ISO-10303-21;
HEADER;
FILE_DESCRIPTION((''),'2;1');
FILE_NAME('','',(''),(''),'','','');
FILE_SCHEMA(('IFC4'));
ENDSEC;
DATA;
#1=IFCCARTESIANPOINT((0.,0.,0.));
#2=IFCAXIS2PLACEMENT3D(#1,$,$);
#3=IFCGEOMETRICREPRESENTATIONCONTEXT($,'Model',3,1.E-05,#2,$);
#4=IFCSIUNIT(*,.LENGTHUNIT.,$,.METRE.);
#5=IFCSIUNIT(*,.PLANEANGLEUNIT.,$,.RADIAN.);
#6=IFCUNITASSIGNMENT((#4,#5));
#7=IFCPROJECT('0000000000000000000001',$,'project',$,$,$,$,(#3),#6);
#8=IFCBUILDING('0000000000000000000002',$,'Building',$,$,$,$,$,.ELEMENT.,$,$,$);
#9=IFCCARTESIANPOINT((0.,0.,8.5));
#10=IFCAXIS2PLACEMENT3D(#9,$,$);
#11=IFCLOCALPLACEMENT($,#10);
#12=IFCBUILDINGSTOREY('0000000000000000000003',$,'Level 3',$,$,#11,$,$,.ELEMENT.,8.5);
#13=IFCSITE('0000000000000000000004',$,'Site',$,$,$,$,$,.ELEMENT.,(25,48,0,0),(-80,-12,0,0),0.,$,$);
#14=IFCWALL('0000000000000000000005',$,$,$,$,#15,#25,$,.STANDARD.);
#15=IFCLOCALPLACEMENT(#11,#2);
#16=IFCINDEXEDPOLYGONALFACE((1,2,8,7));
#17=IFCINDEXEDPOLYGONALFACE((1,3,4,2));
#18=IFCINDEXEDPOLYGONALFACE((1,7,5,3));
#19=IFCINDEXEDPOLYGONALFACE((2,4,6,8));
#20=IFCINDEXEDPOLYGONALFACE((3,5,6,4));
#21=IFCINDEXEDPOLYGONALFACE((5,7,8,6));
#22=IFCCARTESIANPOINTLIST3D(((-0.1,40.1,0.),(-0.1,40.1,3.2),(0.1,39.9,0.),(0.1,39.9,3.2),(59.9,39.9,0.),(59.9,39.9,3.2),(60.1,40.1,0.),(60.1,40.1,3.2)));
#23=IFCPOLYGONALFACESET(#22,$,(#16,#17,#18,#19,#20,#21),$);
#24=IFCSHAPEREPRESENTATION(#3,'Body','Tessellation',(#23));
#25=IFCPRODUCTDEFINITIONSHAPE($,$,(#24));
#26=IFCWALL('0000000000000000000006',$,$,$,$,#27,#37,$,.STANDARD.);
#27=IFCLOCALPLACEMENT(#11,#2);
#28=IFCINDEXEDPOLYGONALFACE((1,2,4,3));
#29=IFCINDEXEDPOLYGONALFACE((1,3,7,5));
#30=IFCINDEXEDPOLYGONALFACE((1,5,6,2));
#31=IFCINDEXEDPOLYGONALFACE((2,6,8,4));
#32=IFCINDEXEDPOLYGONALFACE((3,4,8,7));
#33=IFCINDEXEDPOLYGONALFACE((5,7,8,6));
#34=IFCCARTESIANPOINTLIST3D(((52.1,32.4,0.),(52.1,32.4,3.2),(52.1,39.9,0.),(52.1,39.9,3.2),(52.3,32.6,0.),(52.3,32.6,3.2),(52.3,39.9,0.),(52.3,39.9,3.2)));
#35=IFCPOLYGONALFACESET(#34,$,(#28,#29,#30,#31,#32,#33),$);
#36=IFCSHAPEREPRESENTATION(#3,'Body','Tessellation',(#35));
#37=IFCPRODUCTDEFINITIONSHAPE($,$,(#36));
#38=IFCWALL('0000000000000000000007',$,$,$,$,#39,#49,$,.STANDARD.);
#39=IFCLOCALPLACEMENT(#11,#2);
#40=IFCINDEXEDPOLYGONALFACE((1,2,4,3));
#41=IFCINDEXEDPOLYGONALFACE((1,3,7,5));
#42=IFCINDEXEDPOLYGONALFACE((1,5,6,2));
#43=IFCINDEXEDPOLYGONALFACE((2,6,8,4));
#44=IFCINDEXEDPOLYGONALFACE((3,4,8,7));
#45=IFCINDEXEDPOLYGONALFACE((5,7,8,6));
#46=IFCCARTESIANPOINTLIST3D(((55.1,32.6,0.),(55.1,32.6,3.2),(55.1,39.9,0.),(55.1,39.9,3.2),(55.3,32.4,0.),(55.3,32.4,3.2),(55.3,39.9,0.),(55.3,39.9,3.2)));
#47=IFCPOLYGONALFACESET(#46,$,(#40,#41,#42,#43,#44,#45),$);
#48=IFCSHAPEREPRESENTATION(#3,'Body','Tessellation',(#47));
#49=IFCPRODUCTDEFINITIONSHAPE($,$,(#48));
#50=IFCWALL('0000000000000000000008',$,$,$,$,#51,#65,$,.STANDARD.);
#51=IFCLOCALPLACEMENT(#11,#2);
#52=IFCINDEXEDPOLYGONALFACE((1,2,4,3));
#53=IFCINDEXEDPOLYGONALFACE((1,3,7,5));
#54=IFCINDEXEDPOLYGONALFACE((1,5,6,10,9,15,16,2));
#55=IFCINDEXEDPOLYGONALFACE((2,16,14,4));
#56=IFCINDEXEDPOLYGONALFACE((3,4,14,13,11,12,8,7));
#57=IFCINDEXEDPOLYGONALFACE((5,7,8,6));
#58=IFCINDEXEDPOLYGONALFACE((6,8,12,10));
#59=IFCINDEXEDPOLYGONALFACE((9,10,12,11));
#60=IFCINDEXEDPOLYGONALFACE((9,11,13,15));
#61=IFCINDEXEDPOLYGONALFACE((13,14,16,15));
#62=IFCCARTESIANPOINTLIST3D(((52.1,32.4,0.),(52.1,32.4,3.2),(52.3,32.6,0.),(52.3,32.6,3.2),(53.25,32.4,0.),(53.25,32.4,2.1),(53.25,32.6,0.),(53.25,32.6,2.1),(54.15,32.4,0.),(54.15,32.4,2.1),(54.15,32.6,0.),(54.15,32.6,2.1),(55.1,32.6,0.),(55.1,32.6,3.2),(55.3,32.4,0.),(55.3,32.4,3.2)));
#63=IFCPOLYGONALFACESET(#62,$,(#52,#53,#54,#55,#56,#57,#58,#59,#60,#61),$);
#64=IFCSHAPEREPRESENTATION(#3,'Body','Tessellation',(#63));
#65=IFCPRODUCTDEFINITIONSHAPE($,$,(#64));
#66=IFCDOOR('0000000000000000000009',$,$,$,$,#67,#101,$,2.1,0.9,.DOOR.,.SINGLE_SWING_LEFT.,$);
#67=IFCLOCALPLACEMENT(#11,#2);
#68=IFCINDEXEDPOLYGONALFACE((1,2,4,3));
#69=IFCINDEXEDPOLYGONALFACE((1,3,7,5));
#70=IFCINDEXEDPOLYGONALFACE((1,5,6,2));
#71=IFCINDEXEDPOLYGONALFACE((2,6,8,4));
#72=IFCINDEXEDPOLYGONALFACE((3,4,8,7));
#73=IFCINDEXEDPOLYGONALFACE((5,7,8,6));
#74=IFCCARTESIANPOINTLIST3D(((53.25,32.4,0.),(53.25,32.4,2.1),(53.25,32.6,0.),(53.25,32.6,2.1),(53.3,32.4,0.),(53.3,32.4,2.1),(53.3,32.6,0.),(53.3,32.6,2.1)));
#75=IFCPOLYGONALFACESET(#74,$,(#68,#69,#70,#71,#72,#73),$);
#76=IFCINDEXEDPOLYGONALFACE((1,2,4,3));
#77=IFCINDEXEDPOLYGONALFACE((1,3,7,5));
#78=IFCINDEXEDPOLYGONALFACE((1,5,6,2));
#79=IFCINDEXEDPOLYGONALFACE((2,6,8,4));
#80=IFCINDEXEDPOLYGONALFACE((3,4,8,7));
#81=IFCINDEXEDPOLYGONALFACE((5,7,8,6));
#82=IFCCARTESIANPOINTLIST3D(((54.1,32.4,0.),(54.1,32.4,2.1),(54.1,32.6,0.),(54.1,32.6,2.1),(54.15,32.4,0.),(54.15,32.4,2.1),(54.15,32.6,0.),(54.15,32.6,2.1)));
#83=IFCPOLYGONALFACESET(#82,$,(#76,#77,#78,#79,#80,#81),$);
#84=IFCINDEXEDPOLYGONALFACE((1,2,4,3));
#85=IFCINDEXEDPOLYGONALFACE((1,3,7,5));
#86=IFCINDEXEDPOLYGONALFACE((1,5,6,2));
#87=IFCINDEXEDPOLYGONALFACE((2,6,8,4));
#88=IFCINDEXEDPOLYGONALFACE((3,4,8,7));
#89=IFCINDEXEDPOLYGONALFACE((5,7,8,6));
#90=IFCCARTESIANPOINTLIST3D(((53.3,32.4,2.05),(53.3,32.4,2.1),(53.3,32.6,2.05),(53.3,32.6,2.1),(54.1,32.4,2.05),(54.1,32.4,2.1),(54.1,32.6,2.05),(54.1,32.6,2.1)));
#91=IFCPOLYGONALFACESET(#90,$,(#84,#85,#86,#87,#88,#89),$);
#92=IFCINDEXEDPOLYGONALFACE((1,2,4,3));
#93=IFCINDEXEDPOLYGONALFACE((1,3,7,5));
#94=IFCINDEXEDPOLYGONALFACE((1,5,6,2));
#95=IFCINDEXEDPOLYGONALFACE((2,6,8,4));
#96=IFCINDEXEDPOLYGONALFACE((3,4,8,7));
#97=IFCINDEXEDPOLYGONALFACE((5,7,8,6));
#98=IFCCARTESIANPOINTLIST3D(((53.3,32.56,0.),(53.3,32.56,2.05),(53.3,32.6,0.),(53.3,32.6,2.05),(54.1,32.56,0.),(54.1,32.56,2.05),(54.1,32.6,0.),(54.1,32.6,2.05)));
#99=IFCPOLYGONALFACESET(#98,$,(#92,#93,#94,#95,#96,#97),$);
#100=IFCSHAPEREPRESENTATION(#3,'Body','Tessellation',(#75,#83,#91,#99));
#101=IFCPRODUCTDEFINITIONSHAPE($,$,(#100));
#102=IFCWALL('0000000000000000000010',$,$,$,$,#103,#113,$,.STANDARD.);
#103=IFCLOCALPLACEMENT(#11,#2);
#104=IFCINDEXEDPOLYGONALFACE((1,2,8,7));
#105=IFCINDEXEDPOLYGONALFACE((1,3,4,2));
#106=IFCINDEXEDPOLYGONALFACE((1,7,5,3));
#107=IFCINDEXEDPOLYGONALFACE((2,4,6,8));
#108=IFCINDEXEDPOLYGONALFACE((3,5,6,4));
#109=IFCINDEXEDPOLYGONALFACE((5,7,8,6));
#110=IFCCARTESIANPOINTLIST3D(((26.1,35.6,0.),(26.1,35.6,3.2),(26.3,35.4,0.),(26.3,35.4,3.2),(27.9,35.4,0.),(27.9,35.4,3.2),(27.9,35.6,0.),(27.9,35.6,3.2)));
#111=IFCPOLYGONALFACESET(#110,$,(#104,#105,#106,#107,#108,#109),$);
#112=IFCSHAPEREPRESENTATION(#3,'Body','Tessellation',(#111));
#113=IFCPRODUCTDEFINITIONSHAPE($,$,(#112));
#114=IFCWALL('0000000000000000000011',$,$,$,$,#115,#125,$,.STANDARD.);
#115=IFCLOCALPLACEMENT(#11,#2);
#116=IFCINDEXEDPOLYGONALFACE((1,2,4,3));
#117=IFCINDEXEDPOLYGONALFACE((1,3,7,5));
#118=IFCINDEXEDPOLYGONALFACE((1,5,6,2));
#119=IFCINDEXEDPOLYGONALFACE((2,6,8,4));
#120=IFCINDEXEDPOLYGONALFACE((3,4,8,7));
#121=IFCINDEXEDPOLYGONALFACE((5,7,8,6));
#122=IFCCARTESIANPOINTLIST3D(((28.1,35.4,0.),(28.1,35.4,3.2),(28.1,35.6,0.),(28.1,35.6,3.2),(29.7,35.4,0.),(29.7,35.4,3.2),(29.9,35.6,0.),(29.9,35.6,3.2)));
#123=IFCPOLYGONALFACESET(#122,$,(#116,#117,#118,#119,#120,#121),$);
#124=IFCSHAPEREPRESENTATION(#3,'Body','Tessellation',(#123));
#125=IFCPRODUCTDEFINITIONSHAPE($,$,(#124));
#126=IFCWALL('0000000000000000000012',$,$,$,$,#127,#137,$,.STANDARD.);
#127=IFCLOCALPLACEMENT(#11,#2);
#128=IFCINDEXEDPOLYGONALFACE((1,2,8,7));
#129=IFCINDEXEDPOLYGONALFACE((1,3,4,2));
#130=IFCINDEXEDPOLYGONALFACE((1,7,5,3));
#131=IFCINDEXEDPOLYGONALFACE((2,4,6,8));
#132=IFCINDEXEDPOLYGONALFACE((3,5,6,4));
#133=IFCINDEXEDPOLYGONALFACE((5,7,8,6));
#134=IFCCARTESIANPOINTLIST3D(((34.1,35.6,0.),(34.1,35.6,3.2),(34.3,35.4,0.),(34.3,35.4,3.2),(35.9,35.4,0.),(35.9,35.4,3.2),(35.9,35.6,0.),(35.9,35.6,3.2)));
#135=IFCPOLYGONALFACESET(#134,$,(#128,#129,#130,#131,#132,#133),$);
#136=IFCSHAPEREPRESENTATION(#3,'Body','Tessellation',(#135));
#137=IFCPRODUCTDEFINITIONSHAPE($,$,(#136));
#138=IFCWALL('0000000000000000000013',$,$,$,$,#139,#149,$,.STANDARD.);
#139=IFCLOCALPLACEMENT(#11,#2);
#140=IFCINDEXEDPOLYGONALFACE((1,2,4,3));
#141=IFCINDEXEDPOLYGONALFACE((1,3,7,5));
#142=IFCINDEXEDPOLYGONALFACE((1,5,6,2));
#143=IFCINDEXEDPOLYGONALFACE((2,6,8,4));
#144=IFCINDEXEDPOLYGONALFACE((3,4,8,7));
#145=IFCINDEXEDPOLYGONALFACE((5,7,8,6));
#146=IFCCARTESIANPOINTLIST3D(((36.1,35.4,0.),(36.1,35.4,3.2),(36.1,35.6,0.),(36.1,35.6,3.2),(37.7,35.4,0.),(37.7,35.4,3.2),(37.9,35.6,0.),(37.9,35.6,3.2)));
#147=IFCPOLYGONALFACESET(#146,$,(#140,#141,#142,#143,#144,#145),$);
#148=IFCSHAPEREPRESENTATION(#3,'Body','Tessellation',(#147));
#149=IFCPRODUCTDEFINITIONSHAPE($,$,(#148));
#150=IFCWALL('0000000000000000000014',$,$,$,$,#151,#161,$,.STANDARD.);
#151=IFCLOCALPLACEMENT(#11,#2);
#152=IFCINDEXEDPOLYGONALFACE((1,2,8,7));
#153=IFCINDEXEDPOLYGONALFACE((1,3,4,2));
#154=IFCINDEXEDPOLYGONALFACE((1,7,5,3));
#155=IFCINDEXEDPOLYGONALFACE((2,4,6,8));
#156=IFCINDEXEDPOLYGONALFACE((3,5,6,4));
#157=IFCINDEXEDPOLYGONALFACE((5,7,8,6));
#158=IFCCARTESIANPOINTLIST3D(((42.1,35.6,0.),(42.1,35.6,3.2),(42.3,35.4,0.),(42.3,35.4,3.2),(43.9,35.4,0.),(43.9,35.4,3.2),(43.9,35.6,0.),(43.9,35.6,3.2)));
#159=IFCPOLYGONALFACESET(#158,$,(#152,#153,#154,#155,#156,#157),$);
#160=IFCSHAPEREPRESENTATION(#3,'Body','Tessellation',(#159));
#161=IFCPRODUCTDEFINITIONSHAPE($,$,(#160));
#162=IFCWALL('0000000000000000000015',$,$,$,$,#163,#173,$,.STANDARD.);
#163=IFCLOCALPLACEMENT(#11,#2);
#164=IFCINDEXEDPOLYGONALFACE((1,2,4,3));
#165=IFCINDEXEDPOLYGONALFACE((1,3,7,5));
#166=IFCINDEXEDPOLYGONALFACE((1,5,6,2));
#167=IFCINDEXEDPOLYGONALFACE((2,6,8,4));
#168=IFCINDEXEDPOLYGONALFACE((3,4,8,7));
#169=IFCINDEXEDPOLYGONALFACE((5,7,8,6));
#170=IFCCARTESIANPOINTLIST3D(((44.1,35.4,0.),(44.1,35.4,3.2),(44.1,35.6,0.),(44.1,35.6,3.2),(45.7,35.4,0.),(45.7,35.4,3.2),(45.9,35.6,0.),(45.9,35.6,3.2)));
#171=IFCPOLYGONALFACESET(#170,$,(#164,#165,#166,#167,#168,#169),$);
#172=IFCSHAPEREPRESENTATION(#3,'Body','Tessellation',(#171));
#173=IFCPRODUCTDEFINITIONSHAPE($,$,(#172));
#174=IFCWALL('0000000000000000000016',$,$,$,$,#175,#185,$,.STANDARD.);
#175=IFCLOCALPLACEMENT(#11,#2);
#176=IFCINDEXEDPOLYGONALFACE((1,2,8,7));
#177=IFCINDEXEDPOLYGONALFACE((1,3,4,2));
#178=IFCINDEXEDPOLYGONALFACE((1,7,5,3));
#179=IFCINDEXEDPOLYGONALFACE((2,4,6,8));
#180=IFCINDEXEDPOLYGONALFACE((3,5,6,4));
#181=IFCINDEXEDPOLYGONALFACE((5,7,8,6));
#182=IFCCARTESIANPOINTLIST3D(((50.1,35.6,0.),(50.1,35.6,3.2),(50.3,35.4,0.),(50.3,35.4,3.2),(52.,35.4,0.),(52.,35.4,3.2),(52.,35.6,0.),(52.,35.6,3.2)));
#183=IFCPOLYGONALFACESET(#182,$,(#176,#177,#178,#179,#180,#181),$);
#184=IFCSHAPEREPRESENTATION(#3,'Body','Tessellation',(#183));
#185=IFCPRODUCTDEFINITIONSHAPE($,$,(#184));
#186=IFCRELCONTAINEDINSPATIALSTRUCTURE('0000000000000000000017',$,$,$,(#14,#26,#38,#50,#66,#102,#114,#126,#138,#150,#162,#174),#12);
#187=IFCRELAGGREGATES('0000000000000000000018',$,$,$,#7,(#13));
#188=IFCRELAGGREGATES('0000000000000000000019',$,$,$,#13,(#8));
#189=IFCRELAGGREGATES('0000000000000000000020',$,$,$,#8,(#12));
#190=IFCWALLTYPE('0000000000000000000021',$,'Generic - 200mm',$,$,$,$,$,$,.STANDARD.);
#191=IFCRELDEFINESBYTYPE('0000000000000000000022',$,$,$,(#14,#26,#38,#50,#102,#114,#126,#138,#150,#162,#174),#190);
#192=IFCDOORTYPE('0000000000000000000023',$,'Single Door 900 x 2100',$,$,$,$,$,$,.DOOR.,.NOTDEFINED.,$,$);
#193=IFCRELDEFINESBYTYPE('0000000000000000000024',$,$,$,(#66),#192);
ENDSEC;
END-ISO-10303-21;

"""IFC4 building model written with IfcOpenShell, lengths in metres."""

from ifc_helpers import new_model, si_unit, frame, frame_2d, origin, origin_with_axes, origin_2d, place, context, project, spatial, polyline, rectangle, outline, extrude, type_object, element, fill, save


model = new_model("IFC4")

# Units and contexts
model_context = context("Model", 3, precision=1e-05, world=origin())
ifc_project = project(units=[si_unit("LENGTHUNIT", "METRE"), si_unit("PLANEANGLEUNIT", "RADIAN")], contexts=[model_context])

# Site, building, storey
site = spatial("IfcSite", under=ifc_project, Name="Site", CompositionType="ELEMENT", RefLatitude=(25, 48, 0, 0), RefLongitude=(-80, -12, 0, 0), RefElevation=0.0)
building = spatial("IfcBuilding", under=site, Name="Building", CompositionType="ELEMENT")
storey_placement = place(None, frame((0.0, 0.0, 8.5)))
storey = spatial("IfcBuildingStorey", under=building, at=storey_placement, Name="Level 3", CompositionType="ELEMENT", Elevation=8.5)

# Walls
wall_type = type_object("IfcWallType", Name="Generic - 200mm", PredefinedType="STANDARD")
wall_1_placement = place(None, frame((60.0, 40.0, 8.5), z_axis=(0.0, 0.0, 1.0), x_axis=(-1.0, 0.0, 0.0)))
element("IfcWall", 1, at=wall_1_placement, inside=storey, type_object=wall_type, PredefinedType="STANDARD", context=model_context, shape_type="SweptSolid", body=[
    extrude(outline(polyline([(-0.1, -0.1), (60.1, -0.1), (59.9, 0.1), (0.1, 0.1), (-0.1, -0.1)])), origin(), (0.0, 0.0, 1.0), 3.2),
])
wall_2_placement = place(None, frame((52.2, 32.5, 8.5), z_axis=(0.0, 0.0, 1.0), x_axis=(0.0, 1.0, 0.0)))
element("IfcWall", 2, at=wall_2_placement, inside=storey, type_object=wall_type, PredefinedType="STANDARD", context=model_context, shape_type="SweptSolid", body=[
    extrude(outline(polyline([(0.1, -0.1), (7.4, -0.1), (7.4, 0.1), (-0.1, 0.1), (0.1, -0.1)])), origin(), (0.0, 0.0, 1.0), 3.2),
])
wall_3_placement = place(None, frame((55.2, 32.5, 8.5), z_axis=(0.0, 0.0, 1.0), x_axis=(0.0, 1.0, 0.0)))
element("IfcWall", 3, at=wall_3_placement, inside=storey, type_object=wall_type, PredefinedType="STANDARD", context=model_context, shape_type="SweptSolid", body=[
    extrude(outline(polyline([(-0.1, -0.1), (7.4, -0.1), (7.4, 0.1), (0.1, 0.1), (-0.1, -0.1)])), origin(), (0.0, 0.0, 1.0), 3.2),
])

# Wall, opening, door
wall_4_placement = place(None, frame((52.2, 32.5, 8.5), z_axis=(0.0, 0.0, 1.0), x_axis=(1.0, 0.0, 0.0)))
wall_4 = element("IfcWall", 4, at=wall_4_placement, inside=storey, type_object=wall_type, PredefinedType="STANDARD", context=model_context, shape_type="SweptSolid", body=[
    extrude(outline(polyline([(-0.1, -0.1), (3.1, -0.1), (2.9, 0.1), (0.1, 0.1), (-0.1, -0.1)])), origin(), (0.0, 0.0, 1.0), 3.2),
])
opening_placement = place(wall_4_placement, frame((1.5, 0.0, 0.0), z_axis=(0.0, 0.0, 1.0), x_axis=(1.0, 0.0, 0.0)))
opening = element("IfcOpeningElement", 5, at=opening_placement, cuts=wall_4, PredefinedType="OPENING", context=model_context, shape_type="SweptSolid", body=[
    extrude(rectangle(XDim=0.9, YDim=0.202, at=origin_2d()), origin(), (0.0, 0.0, 1.0), 2.1),
])
door_type = type_object("IfcDoorType", Name="Single Door 900 x 2100", OperationType="NOTDEFINED", PredefinedType="DOOR")
door_placement = place(opening_placement, origin_with_axes())
door = element("IfcDoor", 6, at=door_placement, inside=storey, type_object=door_type, OperationType="SINGLE_SWING_LEFT", OverallHeight=2.1, OverallWidth=0.9, PredefinedType="DOOR", context=model_context, shape_type="SweptSolid", body=[
    extrude(rectangle(XDim=0.05, YDim=0.2, at=frame_2d((-0.425, 0.0))), origin(), (0.0, 0.0, 1.0), 2.1),
    extrude(rectangle(XDim=0.05, YDim=0.2, at=frame_2d((0.425, 0.0))), origin(), (0.0, 0.0, 1.0), 2.1),
    extrude(rectangle(XDim=0.8, YDim=0.2, at=origin_2d()), frame((0.0, 0.0, 2.05)), (0.0, 0.0, 1.0), 0.05),
    extrude(rectangle(XDim=0.8, YDim=0.04, at=frame_2d((0.0, 0.08))), origin(), (0.0, 0.0, 1.0), 2.05),
])
fill(opening, door)

# Walls
wall_5_placement = place(None, frame((26.2, 35.5, 8.5), z_axis=(0.0, 0.0, 1.0), x_axis=(1.0, 0.0, 0.0)))
element("IfcWall", 7, at=wall_5_placement, inside=storey, type_object=wall_type, PredefinedType="STANDARD", context=model_context, shape_type="SweptSolid", body=[
    extrude(outline(polyline([(0.1, -0.1), (1.7, -0.1), (1.7, 0.1), (-0.1, 0.1), (0.1, -0.1)])), origin(), (0.0, 0.0, 1.0), 3.2),
])
wall_6_placement = place(None, frame((29.8, 35.5, 8.5), z_axis=(0.0, 0.0, 1.0), x_axis=(-1.0, 0.0, 0.0)))
element("IfcWall", 8, at=wall_6_placement, inside=storey, type_object=wall_type, PredefinedType="STANDARD", context=model_context, shape_type="SweptSolid", body=[
    extrude(outline(polyline([(-0.1, -0.1), (1.7, -0.1), (1.7, 0.1), (0.1, 0.1), (-0.1, -0.1)])), origin(), (0.0, 0.0, 1.0), 3.2),
])
wall_7_placement = place(None, frame((34.2, 35.5, 8.5), z_axis=(0.0, 0.0, 1.0), x_axis=(1.0, 0.0, 0.0)))
element("IfcWall", 9, at=wall_7_placement, inside=storey, type_object=wall_type, PredefinedType="STANDARD", context=model_context, shape_type="SweptSolid", body=[
    extrude(outline(polyline([(0.1, -0.1), (1.7, -0.1), (1.7, 0.1), (-0.1, 0.1), (0.1, -0.1)])), origin(), (0.0, 0.0, 1.0), 3.2),
])
wall_8_placement = place(None, frame((37.8, 35.5, 8.5), z_axis=(0.0, 0.0, 1.0), x_axis=(-1.0, 0.0, 0.0)))
element("IfcWall", 10, at=wall_8_placement, inside=storey, type_object=wall_type, PredefinedType="STANDARD", context=model_context, shape_type="SweptSolid", body=[
    extrude(outline(polyline([(-0.1, -0.1), (1.7, -0.1), (1.7, 0.1), (0.1, 0.1), (-0.1, -0.1)])), origin(), (0.0, 0.0, 1.0), 3.2),
])
wall_9_placement = place(None, frame((42.2, 35.5, 8.5), z_axis=(0.0, 0.0, 1.0), x_axis=(1.0, 0.0, 0.0)))
element("IfcWall", 11, at=wall_9_placement, inside=storey, type_object=wall_type, PredefinedType="STANDARD", context=model_context, shape_type="SweptSolid", body=[
    extrude(outline(polyline([(0.1, -0.1), (1.7, -0.1), (1.7, 0.1), (-0.1, 0.1), (0.1, -0.1)])), origin(), (0.0, 0.0, 1.0), 3.2),
])
wall_10_placement = place(None, frame((45.8, 35.5, 8.5), z_axis=(0.0, 0.0, 1.0), x_axis=(-1.0, 0.0, 0.0)))
element("IfcWall", 12, at=wall_10_placement, inside=storey, type_object=wall_type, PredefinedType="STANDARD", context=model_context, shape_type="SweptSolid", body=[
    extrude(outline(polyline([(-0.1, -0.1), (1.7, -0.1), (1.7, 0.1), (0.1, 0.1), (-0.1, -0.1)])), origin(), (0.0, 0.0, 1.0), 3.2),
])
wall_11_placement = place(None, frame((50.2, 35.5, 8.5), z_axis=(0.0, 0.0, 1.0), x_axis=(1.0, 0.0, 0.0)))
element("IfcWall", 13, at=wall_11_placement, inside=storey, type_object=wall_type, PredefinedType="STANDARD", context=model_context, shape_type="SweptSolid", body=[
    extrude(outline(polyline([(0.1, -0.1), (1.8, -0.1), (1.8, 0.1), (-0.1, 0.1), (0.1, -0.1)])), origin(), (0.0, 0.0, 1.0), 3.2),
])

save(model, "model.ifc")
